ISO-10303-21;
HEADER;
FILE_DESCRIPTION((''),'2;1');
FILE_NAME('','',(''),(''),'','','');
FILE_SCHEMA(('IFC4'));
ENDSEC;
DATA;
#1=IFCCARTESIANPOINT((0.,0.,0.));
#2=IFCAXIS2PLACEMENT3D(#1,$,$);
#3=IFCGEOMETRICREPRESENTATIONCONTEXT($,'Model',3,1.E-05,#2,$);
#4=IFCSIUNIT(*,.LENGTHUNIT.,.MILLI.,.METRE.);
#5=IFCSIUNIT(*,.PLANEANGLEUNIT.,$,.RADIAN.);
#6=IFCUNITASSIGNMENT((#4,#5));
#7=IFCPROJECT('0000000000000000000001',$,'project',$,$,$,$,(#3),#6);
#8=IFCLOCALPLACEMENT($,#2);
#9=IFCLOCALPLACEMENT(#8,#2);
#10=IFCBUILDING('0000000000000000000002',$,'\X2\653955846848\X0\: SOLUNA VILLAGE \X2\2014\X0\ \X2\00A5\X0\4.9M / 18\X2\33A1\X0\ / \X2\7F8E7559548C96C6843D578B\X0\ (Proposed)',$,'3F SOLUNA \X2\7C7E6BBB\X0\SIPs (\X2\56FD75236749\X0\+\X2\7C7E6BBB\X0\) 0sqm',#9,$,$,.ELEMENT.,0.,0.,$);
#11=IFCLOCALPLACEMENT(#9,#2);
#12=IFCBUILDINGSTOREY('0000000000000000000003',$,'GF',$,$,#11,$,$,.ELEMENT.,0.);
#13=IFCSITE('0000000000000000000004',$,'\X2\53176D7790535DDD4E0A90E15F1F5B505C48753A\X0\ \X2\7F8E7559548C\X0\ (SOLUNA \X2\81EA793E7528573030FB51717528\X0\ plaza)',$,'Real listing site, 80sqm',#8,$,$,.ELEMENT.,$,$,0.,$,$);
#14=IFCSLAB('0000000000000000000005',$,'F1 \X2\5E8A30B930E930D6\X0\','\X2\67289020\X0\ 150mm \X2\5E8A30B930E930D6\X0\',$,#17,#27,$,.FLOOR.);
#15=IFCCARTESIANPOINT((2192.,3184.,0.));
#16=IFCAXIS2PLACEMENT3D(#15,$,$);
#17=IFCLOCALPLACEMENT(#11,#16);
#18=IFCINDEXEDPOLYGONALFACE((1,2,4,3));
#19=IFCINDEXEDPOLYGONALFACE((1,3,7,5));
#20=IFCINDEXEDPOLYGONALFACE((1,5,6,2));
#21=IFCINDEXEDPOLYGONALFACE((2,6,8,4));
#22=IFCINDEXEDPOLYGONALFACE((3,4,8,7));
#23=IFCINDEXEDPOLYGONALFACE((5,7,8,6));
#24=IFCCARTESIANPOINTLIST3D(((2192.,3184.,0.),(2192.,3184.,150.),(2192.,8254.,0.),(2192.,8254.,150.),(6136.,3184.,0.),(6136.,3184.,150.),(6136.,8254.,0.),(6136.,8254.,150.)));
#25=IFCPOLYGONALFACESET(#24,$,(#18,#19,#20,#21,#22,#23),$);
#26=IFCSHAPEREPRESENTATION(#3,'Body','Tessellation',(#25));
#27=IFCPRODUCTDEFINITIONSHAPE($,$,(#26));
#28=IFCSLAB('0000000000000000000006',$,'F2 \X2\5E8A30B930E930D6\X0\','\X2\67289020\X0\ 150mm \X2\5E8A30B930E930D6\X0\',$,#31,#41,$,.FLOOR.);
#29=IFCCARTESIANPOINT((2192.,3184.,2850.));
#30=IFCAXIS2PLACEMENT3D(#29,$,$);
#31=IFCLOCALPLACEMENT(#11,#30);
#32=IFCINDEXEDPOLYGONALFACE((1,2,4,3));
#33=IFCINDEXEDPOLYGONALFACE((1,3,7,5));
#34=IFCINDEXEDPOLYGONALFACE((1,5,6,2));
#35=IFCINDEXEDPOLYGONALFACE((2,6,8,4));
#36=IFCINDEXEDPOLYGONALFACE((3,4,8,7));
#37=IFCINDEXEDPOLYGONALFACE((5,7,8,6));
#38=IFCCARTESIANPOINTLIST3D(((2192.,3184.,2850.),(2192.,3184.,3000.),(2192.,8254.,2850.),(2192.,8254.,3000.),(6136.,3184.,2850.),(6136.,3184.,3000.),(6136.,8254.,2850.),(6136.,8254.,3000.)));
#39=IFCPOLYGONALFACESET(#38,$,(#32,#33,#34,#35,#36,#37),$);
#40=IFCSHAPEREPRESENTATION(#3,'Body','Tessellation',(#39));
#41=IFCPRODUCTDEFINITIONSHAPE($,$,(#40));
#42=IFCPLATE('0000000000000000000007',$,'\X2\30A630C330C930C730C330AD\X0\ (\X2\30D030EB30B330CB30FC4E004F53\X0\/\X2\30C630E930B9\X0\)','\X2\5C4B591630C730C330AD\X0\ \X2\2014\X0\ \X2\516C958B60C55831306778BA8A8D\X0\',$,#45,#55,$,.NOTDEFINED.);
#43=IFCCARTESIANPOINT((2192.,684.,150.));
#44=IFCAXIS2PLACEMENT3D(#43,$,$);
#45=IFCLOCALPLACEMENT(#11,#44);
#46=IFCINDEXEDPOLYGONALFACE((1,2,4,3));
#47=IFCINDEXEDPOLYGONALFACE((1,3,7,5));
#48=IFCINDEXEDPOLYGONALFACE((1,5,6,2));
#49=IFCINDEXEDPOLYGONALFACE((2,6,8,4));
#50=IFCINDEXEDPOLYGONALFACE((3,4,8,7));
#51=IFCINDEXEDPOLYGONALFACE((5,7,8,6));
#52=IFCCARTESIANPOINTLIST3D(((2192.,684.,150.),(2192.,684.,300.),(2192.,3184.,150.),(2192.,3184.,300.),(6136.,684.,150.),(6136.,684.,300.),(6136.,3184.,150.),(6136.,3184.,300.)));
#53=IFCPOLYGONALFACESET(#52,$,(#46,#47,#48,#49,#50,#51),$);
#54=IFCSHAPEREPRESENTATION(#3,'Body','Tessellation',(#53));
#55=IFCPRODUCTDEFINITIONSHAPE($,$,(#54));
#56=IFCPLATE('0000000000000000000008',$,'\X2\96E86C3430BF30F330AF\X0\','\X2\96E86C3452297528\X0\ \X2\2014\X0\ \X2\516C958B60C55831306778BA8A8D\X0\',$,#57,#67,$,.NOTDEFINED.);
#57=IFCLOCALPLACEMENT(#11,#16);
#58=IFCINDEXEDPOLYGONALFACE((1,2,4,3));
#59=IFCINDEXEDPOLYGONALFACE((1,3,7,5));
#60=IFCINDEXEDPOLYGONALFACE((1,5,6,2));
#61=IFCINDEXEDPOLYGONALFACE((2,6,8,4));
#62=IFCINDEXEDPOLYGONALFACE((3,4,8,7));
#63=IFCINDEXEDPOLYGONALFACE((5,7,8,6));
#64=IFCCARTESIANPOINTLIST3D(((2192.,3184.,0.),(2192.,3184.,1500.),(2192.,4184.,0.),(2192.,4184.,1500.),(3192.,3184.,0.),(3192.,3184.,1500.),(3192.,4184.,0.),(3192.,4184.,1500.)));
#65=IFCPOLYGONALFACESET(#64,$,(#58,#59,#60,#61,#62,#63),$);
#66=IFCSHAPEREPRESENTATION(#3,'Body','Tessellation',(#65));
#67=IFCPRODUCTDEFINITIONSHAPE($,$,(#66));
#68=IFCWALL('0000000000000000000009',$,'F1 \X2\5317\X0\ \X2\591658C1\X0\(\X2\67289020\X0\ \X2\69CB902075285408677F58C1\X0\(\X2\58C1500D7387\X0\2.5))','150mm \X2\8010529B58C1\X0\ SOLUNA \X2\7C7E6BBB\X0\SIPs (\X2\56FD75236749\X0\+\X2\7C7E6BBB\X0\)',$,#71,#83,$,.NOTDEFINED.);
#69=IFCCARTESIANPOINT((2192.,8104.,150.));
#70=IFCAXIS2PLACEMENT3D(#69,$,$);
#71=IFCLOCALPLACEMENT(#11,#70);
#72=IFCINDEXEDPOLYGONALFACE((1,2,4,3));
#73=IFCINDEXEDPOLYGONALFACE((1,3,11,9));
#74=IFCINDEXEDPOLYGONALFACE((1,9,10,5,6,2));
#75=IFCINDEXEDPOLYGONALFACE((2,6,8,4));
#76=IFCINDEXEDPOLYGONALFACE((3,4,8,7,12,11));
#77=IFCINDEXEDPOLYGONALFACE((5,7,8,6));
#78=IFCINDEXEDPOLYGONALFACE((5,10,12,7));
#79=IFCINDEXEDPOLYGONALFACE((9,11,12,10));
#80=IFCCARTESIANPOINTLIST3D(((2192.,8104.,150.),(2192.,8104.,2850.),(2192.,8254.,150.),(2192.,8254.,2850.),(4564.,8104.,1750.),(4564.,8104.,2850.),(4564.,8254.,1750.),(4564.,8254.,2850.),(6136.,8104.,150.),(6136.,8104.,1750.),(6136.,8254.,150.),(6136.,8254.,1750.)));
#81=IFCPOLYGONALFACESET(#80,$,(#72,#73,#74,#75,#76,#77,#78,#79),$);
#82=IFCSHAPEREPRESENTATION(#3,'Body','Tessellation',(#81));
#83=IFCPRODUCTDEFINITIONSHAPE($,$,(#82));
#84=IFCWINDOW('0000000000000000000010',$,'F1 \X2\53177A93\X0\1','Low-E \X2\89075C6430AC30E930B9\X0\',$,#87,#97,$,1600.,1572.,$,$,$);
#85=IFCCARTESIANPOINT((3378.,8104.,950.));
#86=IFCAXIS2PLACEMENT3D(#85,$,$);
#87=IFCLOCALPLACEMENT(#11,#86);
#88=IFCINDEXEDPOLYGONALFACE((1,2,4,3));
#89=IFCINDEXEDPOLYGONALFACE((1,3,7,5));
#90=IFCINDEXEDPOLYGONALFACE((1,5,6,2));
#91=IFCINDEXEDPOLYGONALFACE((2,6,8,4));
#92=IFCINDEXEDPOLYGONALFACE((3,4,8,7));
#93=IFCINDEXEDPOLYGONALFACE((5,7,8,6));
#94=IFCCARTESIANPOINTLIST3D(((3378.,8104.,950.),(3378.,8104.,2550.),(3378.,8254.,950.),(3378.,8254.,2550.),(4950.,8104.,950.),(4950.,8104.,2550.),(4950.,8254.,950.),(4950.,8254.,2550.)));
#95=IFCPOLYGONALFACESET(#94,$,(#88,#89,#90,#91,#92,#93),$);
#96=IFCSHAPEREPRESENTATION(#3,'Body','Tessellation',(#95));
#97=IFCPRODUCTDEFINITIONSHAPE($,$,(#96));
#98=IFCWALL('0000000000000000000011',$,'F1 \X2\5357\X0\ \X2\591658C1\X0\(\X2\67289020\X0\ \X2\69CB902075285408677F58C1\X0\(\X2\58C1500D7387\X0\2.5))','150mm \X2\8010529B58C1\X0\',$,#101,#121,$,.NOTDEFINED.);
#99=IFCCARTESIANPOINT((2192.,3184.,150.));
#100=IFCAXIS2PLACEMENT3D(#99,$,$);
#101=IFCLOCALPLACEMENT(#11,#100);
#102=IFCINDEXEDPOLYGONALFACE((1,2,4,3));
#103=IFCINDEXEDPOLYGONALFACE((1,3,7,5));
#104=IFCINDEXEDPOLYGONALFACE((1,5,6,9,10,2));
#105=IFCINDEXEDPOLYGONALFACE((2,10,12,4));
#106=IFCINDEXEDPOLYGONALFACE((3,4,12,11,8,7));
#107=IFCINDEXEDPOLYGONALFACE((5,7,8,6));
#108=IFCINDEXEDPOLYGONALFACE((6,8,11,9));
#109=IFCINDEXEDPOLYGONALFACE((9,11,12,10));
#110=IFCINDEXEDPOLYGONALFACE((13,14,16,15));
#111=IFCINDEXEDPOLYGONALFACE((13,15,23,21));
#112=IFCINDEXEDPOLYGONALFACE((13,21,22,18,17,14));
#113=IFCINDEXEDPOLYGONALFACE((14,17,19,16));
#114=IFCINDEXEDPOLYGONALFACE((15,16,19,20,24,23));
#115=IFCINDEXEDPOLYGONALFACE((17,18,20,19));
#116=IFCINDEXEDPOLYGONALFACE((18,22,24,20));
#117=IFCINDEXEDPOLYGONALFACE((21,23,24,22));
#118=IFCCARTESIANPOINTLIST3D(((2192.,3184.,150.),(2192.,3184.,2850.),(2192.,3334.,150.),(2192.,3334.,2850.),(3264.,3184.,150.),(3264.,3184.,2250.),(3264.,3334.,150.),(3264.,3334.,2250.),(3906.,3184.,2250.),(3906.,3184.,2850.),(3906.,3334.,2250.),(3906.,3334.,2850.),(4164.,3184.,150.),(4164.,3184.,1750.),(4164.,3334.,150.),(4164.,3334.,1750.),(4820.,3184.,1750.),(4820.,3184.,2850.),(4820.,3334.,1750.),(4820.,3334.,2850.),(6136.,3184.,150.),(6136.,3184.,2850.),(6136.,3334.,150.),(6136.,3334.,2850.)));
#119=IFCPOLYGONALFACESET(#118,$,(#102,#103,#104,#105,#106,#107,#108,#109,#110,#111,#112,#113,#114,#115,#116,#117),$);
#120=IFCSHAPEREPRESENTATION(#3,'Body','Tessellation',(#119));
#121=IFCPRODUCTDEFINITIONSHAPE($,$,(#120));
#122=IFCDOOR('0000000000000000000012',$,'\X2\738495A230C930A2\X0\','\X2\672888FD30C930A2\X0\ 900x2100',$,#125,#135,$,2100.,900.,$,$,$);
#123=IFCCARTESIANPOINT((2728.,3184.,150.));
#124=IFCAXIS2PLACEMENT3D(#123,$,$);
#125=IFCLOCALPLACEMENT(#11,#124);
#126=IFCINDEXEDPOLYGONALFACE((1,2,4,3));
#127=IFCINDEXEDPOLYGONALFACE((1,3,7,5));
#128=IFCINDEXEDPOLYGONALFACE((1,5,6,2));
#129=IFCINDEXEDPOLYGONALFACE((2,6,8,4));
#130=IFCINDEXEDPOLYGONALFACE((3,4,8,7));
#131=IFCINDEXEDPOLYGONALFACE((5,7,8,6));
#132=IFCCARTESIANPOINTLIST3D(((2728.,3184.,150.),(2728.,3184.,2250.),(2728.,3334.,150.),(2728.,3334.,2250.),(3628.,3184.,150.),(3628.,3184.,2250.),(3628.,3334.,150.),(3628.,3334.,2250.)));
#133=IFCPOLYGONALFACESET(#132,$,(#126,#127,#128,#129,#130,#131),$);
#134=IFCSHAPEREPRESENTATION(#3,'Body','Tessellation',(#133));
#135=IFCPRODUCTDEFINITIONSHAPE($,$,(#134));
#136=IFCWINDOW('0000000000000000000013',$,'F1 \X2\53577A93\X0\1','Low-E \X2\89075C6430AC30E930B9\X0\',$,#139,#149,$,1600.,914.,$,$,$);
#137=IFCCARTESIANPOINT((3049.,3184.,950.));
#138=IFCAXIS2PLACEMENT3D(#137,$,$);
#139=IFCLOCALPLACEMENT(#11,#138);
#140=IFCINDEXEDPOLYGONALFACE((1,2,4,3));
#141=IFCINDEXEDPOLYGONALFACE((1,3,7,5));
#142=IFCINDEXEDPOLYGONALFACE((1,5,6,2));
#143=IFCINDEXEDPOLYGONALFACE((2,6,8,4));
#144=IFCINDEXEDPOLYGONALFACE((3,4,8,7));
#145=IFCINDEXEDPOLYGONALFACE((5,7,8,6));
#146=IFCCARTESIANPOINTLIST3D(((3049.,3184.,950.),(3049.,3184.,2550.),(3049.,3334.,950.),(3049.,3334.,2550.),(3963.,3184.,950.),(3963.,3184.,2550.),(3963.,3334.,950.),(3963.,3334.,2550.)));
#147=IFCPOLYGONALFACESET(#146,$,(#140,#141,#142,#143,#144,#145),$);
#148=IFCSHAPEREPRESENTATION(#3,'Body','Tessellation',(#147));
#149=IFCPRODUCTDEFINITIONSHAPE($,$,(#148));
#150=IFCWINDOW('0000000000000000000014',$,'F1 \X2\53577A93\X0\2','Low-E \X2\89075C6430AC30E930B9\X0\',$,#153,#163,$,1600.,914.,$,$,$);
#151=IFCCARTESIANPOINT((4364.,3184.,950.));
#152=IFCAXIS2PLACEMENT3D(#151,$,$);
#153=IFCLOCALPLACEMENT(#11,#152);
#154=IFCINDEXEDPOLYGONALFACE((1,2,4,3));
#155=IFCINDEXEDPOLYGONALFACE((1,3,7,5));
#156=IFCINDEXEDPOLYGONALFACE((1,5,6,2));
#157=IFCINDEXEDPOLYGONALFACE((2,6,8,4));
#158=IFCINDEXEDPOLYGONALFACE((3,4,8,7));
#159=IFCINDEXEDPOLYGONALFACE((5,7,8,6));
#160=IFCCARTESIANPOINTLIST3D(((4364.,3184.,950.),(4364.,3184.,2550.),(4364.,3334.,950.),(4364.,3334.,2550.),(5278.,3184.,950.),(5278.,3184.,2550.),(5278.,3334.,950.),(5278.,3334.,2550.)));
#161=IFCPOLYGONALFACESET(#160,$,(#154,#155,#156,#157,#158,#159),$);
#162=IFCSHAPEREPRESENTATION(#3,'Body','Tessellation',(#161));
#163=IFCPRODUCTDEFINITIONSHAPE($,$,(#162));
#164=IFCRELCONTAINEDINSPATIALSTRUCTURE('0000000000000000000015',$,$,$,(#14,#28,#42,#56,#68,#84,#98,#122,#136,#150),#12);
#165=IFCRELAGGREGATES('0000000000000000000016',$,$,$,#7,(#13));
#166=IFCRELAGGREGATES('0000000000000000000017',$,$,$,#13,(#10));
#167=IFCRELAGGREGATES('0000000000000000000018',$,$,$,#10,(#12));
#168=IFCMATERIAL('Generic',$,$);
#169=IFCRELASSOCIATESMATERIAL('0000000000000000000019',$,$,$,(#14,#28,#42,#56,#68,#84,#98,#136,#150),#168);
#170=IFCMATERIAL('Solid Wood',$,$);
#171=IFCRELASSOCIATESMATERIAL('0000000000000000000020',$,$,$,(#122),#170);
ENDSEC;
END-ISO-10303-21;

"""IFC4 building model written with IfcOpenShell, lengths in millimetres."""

from ifc_helpers import new_model, si_unit, frame, frame_2d, origin, place, context, project, spatial, rectangle, extrude, material, element, fill, save


model = new_model("IFC4")

# Units and contexts
model_context = context("Model", 3, precision=1e-05, world=origin())
ifc_project = project(units=[si_unit("LENGTHUNIT", "METRE", prefix="MILLI"), si_unit("PLANEANGLEUNIT", "RADIAN")], contexts=[model_context])

# Site, building, storey
site_placement = place(None, origin())
site = spatial("IfcSite", under=ifc_project, at=site_placement, Name="北海道川上郡弟子屈町 美留和 (SOLUNA 自社用地・共用 plaza)", ObjectType="Real listing site, 80sqm", CompositionType="ELEMENT", RefElevation=0.0)
building_placement = place(site_placement, origin())
building = spatial("IfcBuilding", under=site, at=building_placement, Name="改善案: SOLUNA VILLAGE — ¥4.9M / 18㎡ / 美留和集落型 (Proposed)", ObjectType="3F SOLUNA 籾殻SIPs (国産杉+籾殻) 0sqm", CompositionType="ELEMENT", ElevationOfRefHeight=0.0, ElevationOfTerrain=0.0)
storey_placement = place(building_placement, origin())
storey = spatial("IfcBuildingStorey", under=building, at=storey_placement, Name="GF", CompositionType="ELEMENT", Elevation=0.0)

# Slabs
ifc_material_1 = material(Name="Generic")
slab_1_placement = place(storey_placement, frame((2192.0, 3184.0, 0.0)))
element("IfcSlab", 1, at=slab_1_placement, inside=storey, material=ifc_material_1, Name="F1 床スラブ", Description="木造 150mm 床スラブ", PredefinedType="FLOOR", context=model_context, shape_type="SweptSolid", body=[
    extrude(rectangle(XDim=3944.0, YDim=5070.0, at=frame_2d((1972.0, 2535.0))), frame((2192.0, 3184.0, 0.0)), (0.0, 0.0, 1.0), 150.0),
])
slab_2_placement = place(storey_placement, frame((2192.0, 3184.0, 2850.0)))
element("IfcSlab", 2, at=slab_2_placement, inside=storey, material=ifc_material_1, Name="F2 床スラブ", Description="木造 150mm 床スラブ", PredefinedType="FLOOR", context=model_context, shape_type="SweptSolid", body=[
    extrude(rectangle(XDim=3944.0, YDim=5070.0, at=frame_2d((1972.0, 2535.0))), frame((2192.0, 3184.0, 2850.0)), (0.0, 0.0, 1.0), 150.0),
])

# Plates
plate_1_placement = place(storey_placement, frame((2192.0, 684.0, 150.0)))
element("IfcPlate", 3, at=plate_1_placement, inside=storey, material=ifc_material_1, Name="ウッドデッキ (バルコニー一体/テラス)", Description="屋外デッキ — 公開情報で確認", PredefinedType="NOTDEFINED", context=model_context, shape_type="SweptSolid", body=[
    extrude(rectangle(XDim=3944.0, YDim=2500.0, at=frame_2d((1972.0, 1250.0))), frame((2192.0, 684.0, 150.0)), (0.0, 0.0, 1.0), 150.0),
])
plate_2_placement = place(storey_placement, frame((2192.0, 3184.0, 0.0)))
element("IfcPlate", 4, at=plate_2_placement, inside=storey, material=ifc_material_1, Name="雨水タンク", Description="雨水利用 — 公開情報で確認", PredefinedType="NOTDEFINED", context=model_context, shape_type="SweptSolid", body=[
    extrude(rectangle(XDim=1000.0, YDim=1000.0, at=frame_2d((500.0, 500.0))), frame((2192.0, 3184.0, 0.0)), (0.0, 0.0, 1.0), 1500.0),
])

# Wall, opening, window
wall_1_placement = place(storey_placement, frame((2192.0, 8104.0, 150.0)))
wall_1 = element("IfcWall", 5, at=wall_1_placement, inside=storey, material=ifc_material_1, Name="F1 北 外壁(木造 構造用合板壁(壁倍率2.5))", Description="150mm 耐力壁 SOLUNA 籾殻SIPs (国産杉+籾殻)", PredefinedType="NOTDEFINED", context=model_context, shape_type="SweptSolid", body=[
    extrude(rectangle(XDim=3944.0, YDim=150.0, at=frame_2d((1972.0, 75.0))), frame((2192.0, 8104.0, 150.0)), (0.0, 0.0, 1.0), 2700.0),
])
opening_1_placement = place(storey_placement, frame((3378.0, 8104.0, 950.0)))
opening_1 = element("IfcOpeningElement", 6, at=opening_1_placement, cuts=wall_1, PredefinedType="NOTDEFINED", context=model_context, shape_type="SweptSolid", body=[
    extrude(rectangle(XDim=1572.0, YDim=150.0, at=frame_2d((786.0, 75.0))), frame((3378.0, 8104.0, 950.0)), (0.0, 0.0, 1.0), 1600.0),
])
window_1_placement = place(storey_placement, frame((3378.0, 8104.0, 950.0)))
window_1 = element("IfcWindow", 7, at=window_1_placement, inside=storey, material=ifc_material_1, Name="F1 北窓1", Description="Low-E 複層ガラス", OverallHeight=1600.0, OverallWidth=1572.0, context=model_context, shape_type="SweptSolid", body=[
    extrude(rectangle(XDim=1572.0, YDim=150.0, at=frame_2d((786.0, 75.0))), frame((3378.0, 8104.0, 950.0)), (0.0, 0.0, 1.0), 1600.0),
])
fill(opening_1, window_1)

# Wall, openings, door, windows
wall_2_placement = place(storey_placement, frame((2192.0, 3184.0, 150.0)))
wall_2 = element("IfcWall", 8, at=wall_2_placement, inside=storey, material=ifc_material_1, Name="F1 南 外壁(木造 構造用合板壁(壁倍率2.5))", Description="150mm 耐力壁", PredefinedType="NOTDEFINED", context=model_context, shape_type="SweptSolid", body=[
    extrude(rectangle(XDim=3944.0, YDim=150.0, at=frame_2d((1972.0, 75.0))), frame((2192.0, 3184.0, 150.0)), (0.0, 0.0, 1.0), 2700.0),
])
opening_2_placement = place(storey_placement, frame((2728.0, 3184.0, 150.0)))
opening_2 = element("IfcOpeningElement", 9, at=opening_2_placement, cuts=wall_2, PredefinedType="NOTDEFINED", context=model_context, shape_type="SweptSolid", body=[
    extrude(rectangle(XDim=900.0, YDim=150.0, at=frame_2d((450.0, 75.0))), frame((2728.0, 3184.0, 150.0)), (0.0, 0.0, 1.0), 2100.0),
])
opening_3_placement = place(storey_placement, frame((3049.0, 3184.0, 950.0)))
opening_3 = element("IfcOpeningElement", 10, at=opening_3_placement, cuts=wall_2, PredefinedType="NOTDEFINED", context=model_context, shape_type="SweptSolid", body=[
    extrude(rectangle(XDim=914.0, YDim=150.0, at=frame_2d((457.0, 75.0))), frame((3049.0, 3184.0, 950.0)), (0.0, 0.0, 1.0), 1600.0),
])
opening_4_placement = place(storey_placement, frame((4364.0, 3184.0, 950.0)))
opening_4 = element("IfcOpeningElement", 11, at=opening_4_placement, cuts=wall_2, PredefinedType="NOTDEFINED", context=model_context, shape_type="SweptSolid", body=[
    extrude(rectangle(XDim=914.0, YDim=150.0, at=frame_2d((457.0, 75.0))), frame((4364.0, 3184.0, 950.0)), (0.0, 0.0, 1.0), 1600.0),
])
ifc_material_2 = material(Name="Solid Wood")
door_placement = place(storey_placement, frame((2728.0, 3184.0, 150.0)))
door = element("IfcDoor", 12, at=door_placement, inside=storey, material=ifc_material_2, Name="玄関ドア", Description="木製ドア 900x2100", OverallHeight=2100.0, OverallWidth=900.0, context=model_context, shape_type="SweptSolid", body=[
    extrude(rectangle(XDim=900.0, YDim=150.0, at=frame_2d((450.0, 75.0))), frame((2728.0, 3184.0, 150.0)), (0.0, 0.0, 1.0), 2100.0),
])
fill(opening_2, door)
window_2_placement = place(storey_placement, frame((3049.0, 3184.0, 950.0)))
window_2 = element("IfcWindow", 13, at=window_2_placement, inside=storey, material=ifc_material_1, Name="F1 南窓1", Description="Low-E 複層ガラス", OverallHeight=1600.0, OverallWidth=914.0, context=model_context, shape_type="SweptSolid", body=[
    extrude(rectangle(XDim=914.0, YDim=150.0, at=frame_2d((457.0, 75.0))), frame((3049.0, 3184.0, 950.0)), (0.0, 0.0, 1.0), 1600.0),
])
fill(opening_3, window_2)
window_3_placement = place(storey_placement, frame((4364.0, 3184.0, 950.0)))
window_3 = element("IfcWindow", 14, at=window_3_placement, inside=storey, material=ifc_material_1, Name="F1 南窓2", Description="Low-E 複層ガラス", OverallHeight=1600.0, OverallWidth=914.0, context=model_context, shape_type="SweptSolid", body=[
    extrude(rectangle(XDim=914.0, YDim=150.0, at=frame_2d((457.0, 75.0))), frame((4364.0, 3184.0, 950.0)), (0.0, 0.0, 1.0), 1600.0),
])
fill(opening_4, window_3)

save(model, "model.ifc")
